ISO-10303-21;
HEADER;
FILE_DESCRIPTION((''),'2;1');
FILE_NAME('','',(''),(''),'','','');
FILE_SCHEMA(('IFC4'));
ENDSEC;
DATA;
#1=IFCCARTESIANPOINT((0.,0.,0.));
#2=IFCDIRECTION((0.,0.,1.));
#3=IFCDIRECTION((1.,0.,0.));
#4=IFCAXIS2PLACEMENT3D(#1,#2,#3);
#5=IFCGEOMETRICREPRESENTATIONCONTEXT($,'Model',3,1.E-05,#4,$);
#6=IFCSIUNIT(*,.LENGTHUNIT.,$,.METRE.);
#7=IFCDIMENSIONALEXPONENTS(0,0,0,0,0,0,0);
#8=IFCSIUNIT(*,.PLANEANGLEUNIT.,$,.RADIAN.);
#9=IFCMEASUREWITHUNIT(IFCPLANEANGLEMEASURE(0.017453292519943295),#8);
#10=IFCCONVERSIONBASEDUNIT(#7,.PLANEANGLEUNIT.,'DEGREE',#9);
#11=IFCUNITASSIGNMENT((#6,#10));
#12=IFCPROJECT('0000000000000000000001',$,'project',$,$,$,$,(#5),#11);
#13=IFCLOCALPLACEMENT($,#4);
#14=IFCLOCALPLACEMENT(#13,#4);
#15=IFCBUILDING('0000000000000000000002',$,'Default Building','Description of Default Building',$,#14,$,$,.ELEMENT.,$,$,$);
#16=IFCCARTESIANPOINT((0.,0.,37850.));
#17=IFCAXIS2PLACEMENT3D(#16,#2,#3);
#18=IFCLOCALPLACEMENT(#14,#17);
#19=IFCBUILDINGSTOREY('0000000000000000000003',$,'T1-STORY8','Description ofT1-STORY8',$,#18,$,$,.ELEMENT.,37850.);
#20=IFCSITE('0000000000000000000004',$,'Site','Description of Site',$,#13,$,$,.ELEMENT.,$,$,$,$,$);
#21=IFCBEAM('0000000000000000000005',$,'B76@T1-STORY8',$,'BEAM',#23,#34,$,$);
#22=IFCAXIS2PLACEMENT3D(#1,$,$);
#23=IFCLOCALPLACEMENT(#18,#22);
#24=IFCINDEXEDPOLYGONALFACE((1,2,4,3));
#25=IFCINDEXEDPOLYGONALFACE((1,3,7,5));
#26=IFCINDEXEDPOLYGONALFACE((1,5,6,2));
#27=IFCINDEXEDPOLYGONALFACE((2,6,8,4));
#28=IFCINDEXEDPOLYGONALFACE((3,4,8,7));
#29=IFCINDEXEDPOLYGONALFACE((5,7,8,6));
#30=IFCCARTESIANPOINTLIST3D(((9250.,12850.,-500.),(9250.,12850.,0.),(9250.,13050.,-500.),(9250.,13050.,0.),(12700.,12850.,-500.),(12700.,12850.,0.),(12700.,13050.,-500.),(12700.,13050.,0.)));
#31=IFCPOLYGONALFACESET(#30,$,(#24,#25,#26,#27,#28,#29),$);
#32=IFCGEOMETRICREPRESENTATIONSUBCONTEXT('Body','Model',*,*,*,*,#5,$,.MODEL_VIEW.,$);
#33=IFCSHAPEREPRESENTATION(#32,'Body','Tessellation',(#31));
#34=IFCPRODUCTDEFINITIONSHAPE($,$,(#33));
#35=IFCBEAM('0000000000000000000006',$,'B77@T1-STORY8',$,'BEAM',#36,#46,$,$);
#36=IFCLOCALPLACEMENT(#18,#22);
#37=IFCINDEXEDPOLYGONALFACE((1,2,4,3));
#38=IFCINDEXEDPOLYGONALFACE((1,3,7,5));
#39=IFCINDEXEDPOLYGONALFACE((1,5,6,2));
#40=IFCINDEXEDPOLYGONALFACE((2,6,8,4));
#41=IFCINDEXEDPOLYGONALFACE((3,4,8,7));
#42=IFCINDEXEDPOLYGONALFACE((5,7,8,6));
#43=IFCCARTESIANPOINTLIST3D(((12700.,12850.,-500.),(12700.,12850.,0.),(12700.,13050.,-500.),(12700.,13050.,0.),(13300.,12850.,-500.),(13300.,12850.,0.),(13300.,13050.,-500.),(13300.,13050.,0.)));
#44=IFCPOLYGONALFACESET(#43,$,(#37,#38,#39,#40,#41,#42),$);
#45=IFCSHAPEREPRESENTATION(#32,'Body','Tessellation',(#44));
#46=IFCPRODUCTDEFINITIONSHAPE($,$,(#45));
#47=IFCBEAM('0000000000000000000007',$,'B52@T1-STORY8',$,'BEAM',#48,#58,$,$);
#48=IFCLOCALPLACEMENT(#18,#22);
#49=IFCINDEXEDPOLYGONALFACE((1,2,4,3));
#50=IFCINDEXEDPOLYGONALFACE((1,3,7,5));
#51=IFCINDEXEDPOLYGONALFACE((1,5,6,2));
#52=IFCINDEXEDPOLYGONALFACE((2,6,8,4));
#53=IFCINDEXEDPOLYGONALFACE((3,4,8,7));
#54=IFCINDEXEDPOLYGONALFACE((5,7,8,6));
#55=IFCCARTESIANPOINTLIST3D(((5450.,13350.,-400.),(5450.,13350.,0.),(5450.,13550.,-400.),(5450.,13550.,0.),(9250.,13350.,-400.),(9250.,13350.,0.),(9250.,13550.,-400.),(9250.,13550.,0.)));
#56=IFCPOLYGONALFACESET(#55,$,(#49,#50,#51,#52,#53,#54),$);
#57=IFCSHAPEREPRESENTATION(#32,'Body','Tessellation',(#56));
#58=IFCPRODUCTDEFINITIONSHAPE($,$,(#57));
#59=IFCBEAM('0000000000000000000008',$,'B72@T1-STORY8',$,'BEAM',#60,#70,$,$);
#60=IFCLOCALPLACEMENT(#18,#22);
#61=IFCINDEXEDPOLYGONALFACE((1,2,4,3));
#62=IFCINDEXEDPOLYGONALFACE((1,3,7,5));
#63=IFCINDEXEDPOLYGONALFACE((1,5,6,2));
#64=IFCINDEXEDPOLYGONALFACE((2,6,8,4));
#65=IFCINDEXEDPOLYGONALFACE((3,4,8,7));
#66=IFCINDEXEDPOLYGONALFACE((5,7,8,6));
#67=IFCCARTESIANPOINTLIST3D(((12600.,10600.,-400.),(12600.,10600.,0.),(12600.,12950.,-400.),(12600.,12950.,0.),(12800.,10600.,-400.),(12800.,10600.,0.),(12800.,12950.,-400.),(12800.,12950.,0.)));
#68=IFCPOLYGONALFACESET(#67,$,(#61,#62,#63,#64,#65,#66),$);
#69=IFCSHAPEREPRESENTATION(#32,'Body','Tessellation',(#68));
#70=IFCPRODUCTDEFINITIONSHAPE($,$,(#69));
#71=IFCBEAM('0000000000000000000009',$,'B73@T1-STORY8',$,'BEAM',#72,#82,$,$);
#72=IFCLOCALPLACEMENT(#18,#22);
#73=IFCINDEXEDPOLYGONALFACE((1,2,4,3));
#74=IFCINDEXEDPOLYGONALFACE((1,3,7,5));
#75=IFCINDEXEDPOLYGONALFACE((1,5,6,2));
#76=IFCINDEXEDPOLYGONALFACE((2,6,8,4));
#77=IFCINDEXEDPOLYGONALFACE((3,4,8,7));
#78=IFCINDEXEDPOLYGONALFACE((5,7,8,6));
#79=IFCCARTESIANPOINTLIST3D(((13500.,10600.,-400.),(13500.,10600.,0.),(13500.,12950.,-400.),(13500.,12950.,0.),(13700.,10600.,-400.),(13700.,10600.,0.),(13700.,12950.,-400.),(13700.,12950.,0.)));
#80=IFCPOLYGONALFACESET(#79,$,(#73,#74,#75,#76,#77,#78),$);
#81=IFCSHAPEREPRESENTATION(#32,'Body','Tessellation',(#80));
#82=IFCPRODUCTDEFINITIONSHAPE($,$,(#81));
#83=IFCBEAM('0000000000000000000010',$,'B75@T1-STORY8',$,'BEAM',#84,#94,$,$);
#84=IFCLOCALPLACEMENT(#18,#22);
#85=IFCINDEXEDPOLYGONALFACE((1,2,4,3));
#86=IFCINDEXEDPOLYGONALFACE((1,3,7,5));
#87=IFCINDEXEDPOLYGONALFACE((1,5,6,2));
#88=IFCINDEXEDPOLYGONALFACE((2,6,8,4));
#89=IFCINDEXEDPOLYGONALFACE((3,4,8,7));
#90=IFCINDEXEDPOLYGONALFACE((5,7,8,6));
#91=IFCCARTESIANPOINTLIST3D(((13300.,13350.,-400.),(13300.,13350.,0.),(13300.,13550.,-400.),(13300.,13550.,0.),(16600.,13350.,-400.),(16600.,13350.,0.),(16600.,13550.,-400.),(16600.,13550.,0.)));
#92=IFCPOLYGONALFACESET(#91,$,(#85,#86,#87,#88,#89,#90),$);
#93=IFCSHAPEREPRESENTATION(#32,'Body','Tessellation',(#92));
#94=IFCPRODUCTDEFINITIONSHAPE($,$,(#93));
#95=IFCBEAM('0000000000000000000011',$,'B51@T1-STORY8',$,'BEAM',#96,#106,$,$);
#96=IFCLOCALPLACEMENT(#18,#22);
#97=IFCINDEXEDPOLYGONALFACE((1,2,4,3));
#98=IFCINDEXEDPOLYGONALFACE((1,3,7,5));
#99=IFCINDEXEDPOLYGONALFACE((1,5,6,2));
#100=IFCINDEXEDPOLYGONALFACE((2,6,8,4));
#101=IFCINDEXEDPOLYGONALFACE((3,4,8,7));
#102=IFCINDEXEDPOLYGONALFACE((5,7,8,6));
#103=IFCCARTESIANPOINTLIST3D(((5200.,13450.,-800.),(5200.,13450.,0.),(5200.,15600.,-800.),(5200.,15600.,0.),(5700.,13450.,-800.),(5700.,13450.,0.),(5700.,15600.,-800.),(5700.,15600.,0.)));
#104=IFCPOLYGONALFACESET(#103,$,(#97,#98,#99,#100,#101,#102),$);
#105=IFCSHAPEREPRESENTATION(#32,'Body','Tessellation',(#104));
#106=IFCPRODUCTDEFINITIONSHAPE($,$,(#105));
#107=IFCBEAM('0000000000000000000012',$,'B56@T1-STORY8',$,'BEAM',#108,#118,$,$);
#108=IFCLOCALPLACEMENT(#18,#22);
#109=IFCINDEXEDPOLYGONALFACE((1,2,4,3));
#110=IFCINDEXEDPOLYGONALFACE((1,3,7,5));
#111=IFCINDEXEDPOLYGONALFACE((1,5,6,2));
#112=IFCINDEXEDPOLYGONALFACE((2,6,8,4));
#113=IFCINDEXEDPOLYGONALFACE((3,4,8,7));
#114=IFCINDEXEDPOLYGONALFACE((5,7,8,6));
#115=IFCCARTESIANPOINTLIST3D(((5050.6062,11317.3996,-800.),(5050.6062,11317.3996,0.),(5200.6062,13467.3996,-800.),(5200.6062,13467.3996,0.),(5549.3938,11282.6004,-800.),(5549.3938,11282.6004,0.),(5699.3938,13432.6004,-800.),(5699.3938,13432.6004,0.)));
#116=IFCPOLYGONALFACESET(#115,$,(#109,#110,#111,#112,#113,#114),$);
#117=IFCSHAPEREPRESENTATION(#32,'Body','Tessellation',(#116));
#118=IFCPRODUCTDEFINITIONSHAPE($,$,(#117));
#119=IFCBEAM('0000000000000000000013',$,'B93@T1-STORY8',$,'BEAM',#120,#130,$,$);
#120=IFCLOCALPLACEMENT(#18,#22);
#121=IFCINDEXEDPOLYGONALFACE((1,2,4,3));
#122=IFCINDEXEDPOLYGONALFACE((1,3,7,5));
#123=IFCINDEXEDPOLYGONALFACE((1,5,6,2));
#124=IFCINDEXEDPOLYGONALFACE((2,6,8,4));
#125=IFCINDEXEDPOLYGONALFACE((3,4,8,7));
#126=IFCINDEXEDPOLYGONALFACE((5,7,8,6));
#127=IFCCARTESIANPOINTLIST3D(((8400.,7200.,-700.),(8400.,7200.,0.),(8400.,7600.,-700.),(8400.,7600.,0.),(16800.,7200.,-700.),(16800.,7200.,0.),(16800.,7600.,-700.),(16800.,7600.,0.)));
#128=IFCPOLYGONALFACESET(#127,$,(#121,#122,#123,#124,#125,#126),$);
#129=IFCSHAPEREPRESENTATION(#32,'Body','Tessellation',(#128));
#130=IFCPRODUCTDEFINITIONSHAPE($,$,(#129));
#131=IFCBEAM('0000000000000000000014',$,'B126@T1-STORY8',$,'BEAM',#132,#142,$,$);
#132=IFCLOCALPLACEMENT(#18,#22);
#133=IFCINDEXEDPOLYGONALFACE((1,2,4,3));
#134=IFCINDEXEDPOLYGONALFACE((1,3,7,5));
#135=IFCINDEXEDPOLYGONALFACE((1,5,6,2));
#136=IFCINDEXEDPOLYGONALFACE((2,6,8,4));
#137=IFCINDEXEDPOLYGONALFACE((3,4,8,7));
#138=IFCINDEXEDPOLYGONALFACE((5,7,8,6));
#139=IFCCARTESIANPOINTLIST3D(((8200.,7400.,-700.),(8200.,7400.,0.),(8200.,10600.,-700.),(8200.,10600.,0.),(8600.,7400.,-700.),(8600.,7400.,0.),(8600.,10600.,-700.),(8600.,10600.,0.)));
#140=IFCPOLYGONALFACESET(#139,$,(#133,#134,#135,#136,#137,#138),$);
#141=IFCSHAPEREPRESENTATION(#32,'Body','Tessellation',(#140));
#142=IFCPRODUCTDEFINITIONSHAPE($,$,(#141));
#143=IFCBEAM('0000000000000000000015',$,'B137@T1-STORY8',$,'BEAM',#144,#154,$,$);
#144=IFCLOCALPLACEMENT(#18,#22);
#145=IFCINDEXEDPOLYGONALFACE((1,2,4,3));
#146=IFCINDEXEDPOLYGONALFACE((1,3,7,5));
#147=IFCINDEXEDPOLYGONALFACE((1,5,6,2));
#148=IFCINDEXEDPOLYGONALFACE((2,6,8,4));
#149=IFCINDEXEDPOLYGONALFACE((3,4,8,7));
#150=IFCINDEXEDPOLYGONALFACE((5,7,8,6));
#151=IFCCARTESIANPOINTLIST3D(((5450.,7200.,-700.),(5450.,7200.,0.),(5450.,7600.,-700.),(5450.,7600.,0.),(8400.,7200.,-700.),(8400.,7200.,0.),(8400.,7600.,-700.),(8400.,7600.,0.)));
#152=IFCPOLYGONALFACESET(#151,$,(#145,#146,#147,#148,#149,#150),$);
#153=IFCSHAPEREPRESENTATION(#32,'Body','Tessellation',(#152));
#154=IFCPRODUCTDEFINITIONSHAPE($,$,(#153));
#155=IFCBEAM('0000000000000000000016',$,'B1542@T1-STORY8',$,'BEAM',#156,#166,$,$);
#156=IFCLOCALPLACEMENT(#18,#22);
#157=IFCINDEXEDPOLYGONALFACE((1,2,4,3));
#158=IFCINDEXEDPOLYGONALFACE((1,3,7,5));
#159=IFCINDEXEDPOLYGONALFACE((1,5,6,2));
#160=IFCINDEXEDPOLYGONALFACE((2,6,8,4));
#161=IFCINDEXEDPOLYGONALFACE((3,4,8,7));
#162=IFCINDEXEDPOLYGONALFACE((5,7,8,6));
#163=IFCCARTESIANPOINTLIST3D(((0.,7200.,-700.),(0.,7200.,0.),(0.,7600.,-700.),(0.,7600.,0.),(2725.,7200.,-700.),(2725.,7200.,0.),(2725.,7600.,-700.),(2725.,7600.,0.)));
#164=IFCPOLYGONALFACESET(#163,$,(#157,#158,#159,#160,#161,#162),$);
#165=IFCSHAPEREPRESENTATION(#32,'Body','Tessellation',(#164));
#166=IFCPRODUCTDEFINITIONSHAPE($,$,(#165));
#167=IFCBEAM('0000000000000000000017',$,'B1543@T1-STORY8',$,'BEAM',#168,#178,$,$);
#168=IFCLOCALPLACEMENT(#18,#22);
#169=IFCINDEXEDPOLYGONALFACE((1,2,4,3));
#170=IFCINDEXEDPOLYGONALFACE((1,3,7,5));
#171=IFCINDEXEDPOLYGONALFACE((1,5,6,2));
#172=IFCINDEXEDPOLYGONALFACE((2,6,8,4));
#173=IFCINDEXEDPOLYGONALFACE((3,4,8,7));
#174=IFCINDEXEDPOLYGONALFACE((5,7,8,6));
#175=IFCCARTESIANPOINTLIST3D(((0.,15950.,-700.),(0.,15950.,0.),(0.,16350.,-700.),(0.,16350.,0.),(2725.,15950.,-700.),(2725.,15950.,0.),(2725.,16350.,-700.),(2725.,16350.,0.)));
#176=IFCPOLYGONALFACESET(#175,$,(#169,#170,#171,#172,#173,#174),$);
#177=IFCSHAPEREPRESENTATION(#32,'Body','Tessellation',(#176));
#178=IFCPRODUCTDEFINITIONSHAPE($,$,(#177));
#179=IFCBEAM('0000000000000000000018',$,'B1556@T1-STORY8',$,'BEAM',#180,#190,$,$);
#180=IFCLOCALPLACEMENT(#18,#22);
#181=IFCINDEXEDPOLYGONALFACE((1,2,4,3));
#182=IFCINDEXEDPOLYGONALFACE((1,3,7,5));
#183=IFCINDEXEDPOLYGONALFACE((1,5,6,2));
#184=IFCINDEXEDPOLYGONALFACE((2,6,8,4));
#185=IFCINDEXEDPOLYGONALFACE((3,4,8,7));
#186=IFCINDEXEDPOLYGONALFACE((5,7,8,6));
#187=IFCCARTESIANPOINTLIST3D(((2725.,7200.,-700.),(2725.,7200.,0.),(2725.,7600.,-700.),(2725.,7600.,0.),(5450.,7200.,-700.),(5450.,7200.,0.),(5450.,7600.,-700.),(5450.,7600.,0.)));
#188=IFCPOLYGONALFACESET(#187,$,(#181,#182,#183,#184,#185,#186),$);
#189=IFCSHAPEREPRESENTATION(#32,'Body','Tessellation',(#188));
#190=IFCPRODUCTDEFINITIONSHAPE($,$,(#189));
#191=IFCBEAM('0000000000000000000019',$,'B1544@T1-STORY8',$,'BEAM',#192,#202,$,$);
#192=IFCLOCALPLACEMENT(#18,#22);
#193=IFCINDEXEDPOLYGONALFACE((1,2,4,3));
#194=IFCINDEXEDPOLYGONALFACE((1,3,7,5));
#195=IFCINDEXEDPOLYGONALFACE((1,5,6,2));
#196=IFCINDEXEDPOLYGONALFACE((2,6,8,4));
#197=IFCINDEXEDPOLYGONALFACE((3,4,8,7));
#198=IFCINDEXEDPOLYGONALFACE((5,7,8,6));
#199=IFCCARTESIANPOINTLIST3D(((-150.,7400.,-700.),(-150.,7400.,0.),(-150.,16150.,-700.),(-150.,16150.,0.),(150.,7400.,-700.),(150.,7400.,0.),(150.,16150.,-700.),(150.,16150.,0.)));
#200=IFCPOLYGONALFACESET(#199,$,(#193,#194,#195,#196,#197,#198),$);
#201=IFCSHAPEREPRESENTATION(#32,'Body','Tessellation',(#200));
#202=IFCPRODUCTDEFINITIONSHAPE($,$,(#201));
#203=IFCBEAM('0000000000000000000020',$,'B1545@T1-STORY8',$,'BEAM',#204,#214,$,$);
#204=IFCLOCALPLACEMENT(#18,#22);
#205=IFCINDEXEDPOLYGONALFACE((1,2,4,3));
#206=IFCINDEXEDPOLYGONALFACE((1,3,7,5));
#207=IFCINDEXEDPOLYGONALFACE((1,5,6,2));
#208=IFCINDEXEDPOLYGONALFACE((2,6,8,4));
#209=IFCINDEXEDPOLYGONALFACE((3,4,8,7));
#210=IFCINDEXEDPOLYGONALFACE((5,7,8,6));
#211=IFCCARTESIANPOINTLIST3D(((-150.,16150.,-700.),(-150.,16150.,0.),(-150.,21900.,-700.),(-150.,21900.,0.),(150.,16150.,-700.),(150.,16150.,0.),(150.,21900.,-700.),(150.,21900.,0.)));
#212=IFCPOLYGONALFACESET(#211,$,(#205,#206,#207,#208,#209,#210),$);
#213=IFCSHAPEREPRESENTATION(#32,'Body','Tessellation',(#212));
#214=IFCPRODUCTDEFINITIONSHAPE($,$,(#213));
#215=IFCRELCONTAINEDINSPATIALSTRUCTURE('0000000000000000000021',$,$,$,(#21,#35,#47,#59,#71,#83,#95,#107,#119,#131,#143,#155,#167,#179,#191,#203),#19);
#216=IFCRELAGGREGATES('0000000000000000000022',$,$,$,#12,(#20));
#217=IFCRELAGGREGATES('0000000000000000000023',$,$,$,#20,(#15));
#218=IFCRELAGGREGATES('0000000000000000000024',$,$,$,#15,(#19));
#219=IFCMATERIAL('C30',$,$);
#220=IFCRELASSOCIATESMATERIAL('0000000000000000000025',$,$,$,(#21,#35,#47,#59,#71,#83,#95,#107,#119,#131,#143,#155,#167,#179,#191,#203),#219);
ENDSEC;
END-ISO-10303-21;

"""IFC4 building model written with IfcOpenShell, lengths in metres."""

from ifc_helpers import new_model, entity, si_unit, converted_unit, frame, origin_with_axes, place, context, subcontext, project, spatial, rectangle, extrude, material, element, save


model = new_model("IFC4")

# Units and contexts
model_context = context("Model", 3, precision=1e-05, world=origin_with_axes())
body_context = subcontext(model_context, "Body", "Model", "MODEL_VIEW")
ifc_project = project(units=[si_unit("LENGTHUNIT", "METRE"), converted_unit("PLANEANGLEUNIT", "DEGREE", entity("IfcPlaneAngleMeasure", 0.017453292519943295), si_unit("PLANEANGLEUNIT", "RADIAN"), dimensions=[0, 0, 0, 0, 0, 0, 0])], contexts=[model_context])

# Site, building, storey
site_placement = place(None, origin_with_axes())
site = spatial("IfcSite", under=ifc_project, at=site_placement, Name="Site", Description="Description of Site", CompositionType="ELEMENT")
building_placement = place(site_placement, origin_with_axes())
building = spatial("IfcBuilding", under=site, at=building_placement, Name="Default Building", Description="Description of Default Building", CompositionType="ELEMENT")
storey_placement = place(building_placement, frame((0.0, 0.0, 37850.0), z_axis=(0.0, 0.0, 1.0), x_axis=(1.0, 0.0, 0.0)))
storey = spatial("IfcBuildingStorey", under=building, at=storey_placement, Name="T1-STORY8", Description="Description ofT1-STORY8", CompositionType="ELEMENT", Elevation=37850.0)

# Beams
ifc_material_1 = material(Name="C30")
beam_1_placement = place(storey_placement, frame((9250.0, 12950.0, -250.0), z_axis=(1.0, 0.0, 0.0), x_axis=(0.0, 1.0, 0.0)))
element("IfcBeam", 1, at=beam_1_placement, inside=storey, material=ifc_material_1, Name="B76@T1-STORY8", ObjectType="BEAM", context=body_context, shape_type="SweptSolid", body=[
    extrude(rectangle(XDim=200.0, YDim=500.0), origin_with_axes(), (0.0, 0.0, 1.0), 3450.0),
])
beam_2_placement = place(storey_placement, frame((12700.0, 12950.0, -250.0), z_axis=(1.0, 0.0, 0.0), x_axis=(0.0, 1.0, 0.0)))
element("IfcBeam", 2, at=beam_2_placement, inside=storey, material=ifc_material_1, Name="B77@T1-STORY8", ObjectType="BEAM", context=body_context, shape_type="SweptSolid", body=[
    extrude(rectangle(XDim=200.0, YDim=500.0), origin_with_axes(), (0.0, 0.0, 1.0), 600.0),
])
beam_3_placement = place(storey_placement, frame((5450.0, 13450.0, -200.0), z_axis=(1.0, 0.0, 0.0), x_axis=(0.0, 1.0, 0.0)))
element("IfcBeam", 3, at=beam_3_placement, inside=storey, material=ifc_material_1, Name="B52@T1-STORY8", ObjectType="BEAM", context=body_context, shape_type="SweptSolid", body=[
    extrude(rectangle(XDim=200.0, YDim=400.0), origin_with_axes(), (0.0, 0.0, 1.0), 3800.0),
])
for number, where, z_axis, x_axis, name in (
    (4, (12700.0, 10600.0, -200.0), (0.0, 1.0, 0.0), (-1.0, 0.0, 0.0), "B72@T1-STORY8"),
    (5, (13600.0, 10600.0, -200.0), (0.0, 1.0, 0.0), (-1.0, 0.0, 0.0), "B73@T1-STORY8"),
):
    element("IfcBeam", number, at=place(storey_placement, frame(where, z_axis=z_axis, x_axis=x_axis)), inside=storey, material=ifc_material_1, Name=name, ObjectType="BEAM", context=body_context, shape_type="SweptSolid", body=[
        extrude(rectangle(XDim=200.0, YDim=400.0), origin_with_axes(), (0.0, 0.0, 1.0), 2350.0),
    ])
beam_4_placement = place(storey_placement, frame((13300.0, 13450.0, -200.0), z_axis=(1.0, 0.0, 0.0), x_axis=(0.0, 1.0, 0.0)))
element("IfcBeam", 6, at=beam_4_placement, inside=storey, material=ifc_material_1, Name="B75@T1-STORY8", ObjectType="BEAM", context=body_context, shape_type="SweptSolid", body=[
    extrude(rectangle(XDim=200.0, YDim=400.0), origin_with_axes(), (0.0, 0.0, 1.0), 3300.0),
])
beam_5_placement = place(storey_placement, frame((5450.0, 13450.0, -400.0), z_axis=(0.0, 1.0, 0.0), x_axis=(-1.0, 0.0, 0.0)))
element("IfcBeam", 7, at=beam_5_placement, inside=storey, material=ifc_material_1, Name="B51@T1-STORY8", ObjectType="BEAM", context=body_context, shape_type="SweptSolid", body=[
    extrude(rectangle(XDim=500.0, YDim=800.0), origin_with_axes(), (0.0, 0.0, 1.0), 2150.0),
])
beam_6_placement = place(storey_placement, frame((5300.0, 11300.0, -400.0), z_axis=(0.069598, 0.997575, 0.0), x_axis=(-0.997575, 0.069598, 0.0)))
element("IfcBeam", 8, at=beam_6_placement, inside=storey, material=ifc_material_1, Name="B56@T1-STORY8", ObjectType="BEAM", context=body_context, shape_type="SweptSolid", body=[
    extrude(rectangle(XDim=500.0, YDim=800.0), origin_with_axes(), (0.0, 0.0, 1.0), 2155.2262),
])
beam_7_placement = place(storey_placement, frame((8400.0, 7400.0, -350.0), z_axis=(1.0, 0.0, 0.0), x_axis=(0.0, 1.0, 0.0)))
element("IfcBeam", 9, at=beam_7_placement, inside=storey, material=ifc_material_1, Name="B93@T1-STORY8", ObjectType="BEAM", context=body_context, shape_type="SweptSolid", body=[
    extrude(rectangle(XDim=400.0, YDim=700.0), origin_with_axes(), (0.0, 0.0, 1.0), 8400.0),
])
beam_8_placement = place(storey_placement, frame((8400.0, 7400.0, -350.0), z_axis=(0.0, 1.0, 0.0), x_axis=(-1.0, 0.0, 0.0)))
element("IfcBeam", 10, at=beam_8_placement, inside=storey, material=ifc_material_1, Name="B126@T1-STORY8", ObjectType="BEAM", context=body_context, shape_type="SweptSolid", body=[
    extrude(rectangle(XDim=400.0, YDim=700.0), origin_with_axes(), (0.0, 0.0, 1.0), 3200.0),
])
beam_9_placement = place(storey_placement, frame((5450.0, 7400.0, -350.0), z_axis=(1.0, 0.0, 0.0), x_axis=(0.0, 1.0, 0.0)))
element("IfcBeam", 11, at=beam_9_placement, inside=storey, material=ifc_material_1, Name="B137@T1-STORY8", ObjectType="BEAM", context=body_context, shape_type="SweptSolid", body=[
    extrude(rectangle(XDim=400.0, YDim=700.0), origin_with_axes(), (0.0, 0.0, 1.0), 2950.0),
])
for number, where, z_axis, x_axis, name in (
    (12, (0.0, 7400.0, -350.0), (1.0, 0.0, 0.0), (0.0, 1.0, 0.0), "B1542@T1-STORY8"),
    (13, (0.0, 16150.0, -350.0), (1.0, 0.0, 0.0), (0.0, 1.0, 0.0), "B1543@T1-STORY8"),
    (14, (2725.0, 7400.0, -350.0), (1.0, 0.0, 0.0), (0.0, 1.0, 0.0), "B1556@T1-STORY8"),
):
    element("IfcBeam", number, at=place(storey_placement, frame(where, z_axis=z_axis, x_axis=x_axis)), inside=storey, material=ifc_material_1, Name=name, ObjectType="BEAM", context=body_context, shape_type="SweptSolid", body=[
        extrude(rectangle(XDim=400.0, YDim=700.0), origin_with_axes(), (0.0, 0.0, 1.0), 2725.0),
    ])
beam_10_placement = place(storey_placement, frame((0.0, 7400.0, -350.0), z_axis=(0.0, 1.0, 0.0), x_axis=(-1.0, 0.0, 0.0)))
element("IfcBeam", 15, at=beam_10_placement, inside=storey, material=ifc_material_1, Name="B1544@T1-STORY8", ObjectType="BEAM", context=body_context, shape_type="SweptSolid", body=[
    extrude(rectangle(XDim=300.0, YDim=700.0), origin_with_axes(), (0.0, 0.0, 1.0), 8750.0),
])
beam_11_placement = place(storey_placement, frame((0.0, 16150.0, -350.0), z_axis=(0.0, 1.0, 0.0), x_axis=(-1.0, 0.0, 0.0)))
element("IfcBeam", 16, at=beam_11_placement, inside=storey, material=ifc_material_1, Name="B1545@T1-STORY8", ObjectType="BEAM", context=body_context, shape_type="SweptSolid", body=[
    extrude(rectangle(XDim=300.0, YDim=700.0), origin_with_axes(), (0.0, 0.0, 1.0), 5750.0),
])

save(model, "model.ifc")
